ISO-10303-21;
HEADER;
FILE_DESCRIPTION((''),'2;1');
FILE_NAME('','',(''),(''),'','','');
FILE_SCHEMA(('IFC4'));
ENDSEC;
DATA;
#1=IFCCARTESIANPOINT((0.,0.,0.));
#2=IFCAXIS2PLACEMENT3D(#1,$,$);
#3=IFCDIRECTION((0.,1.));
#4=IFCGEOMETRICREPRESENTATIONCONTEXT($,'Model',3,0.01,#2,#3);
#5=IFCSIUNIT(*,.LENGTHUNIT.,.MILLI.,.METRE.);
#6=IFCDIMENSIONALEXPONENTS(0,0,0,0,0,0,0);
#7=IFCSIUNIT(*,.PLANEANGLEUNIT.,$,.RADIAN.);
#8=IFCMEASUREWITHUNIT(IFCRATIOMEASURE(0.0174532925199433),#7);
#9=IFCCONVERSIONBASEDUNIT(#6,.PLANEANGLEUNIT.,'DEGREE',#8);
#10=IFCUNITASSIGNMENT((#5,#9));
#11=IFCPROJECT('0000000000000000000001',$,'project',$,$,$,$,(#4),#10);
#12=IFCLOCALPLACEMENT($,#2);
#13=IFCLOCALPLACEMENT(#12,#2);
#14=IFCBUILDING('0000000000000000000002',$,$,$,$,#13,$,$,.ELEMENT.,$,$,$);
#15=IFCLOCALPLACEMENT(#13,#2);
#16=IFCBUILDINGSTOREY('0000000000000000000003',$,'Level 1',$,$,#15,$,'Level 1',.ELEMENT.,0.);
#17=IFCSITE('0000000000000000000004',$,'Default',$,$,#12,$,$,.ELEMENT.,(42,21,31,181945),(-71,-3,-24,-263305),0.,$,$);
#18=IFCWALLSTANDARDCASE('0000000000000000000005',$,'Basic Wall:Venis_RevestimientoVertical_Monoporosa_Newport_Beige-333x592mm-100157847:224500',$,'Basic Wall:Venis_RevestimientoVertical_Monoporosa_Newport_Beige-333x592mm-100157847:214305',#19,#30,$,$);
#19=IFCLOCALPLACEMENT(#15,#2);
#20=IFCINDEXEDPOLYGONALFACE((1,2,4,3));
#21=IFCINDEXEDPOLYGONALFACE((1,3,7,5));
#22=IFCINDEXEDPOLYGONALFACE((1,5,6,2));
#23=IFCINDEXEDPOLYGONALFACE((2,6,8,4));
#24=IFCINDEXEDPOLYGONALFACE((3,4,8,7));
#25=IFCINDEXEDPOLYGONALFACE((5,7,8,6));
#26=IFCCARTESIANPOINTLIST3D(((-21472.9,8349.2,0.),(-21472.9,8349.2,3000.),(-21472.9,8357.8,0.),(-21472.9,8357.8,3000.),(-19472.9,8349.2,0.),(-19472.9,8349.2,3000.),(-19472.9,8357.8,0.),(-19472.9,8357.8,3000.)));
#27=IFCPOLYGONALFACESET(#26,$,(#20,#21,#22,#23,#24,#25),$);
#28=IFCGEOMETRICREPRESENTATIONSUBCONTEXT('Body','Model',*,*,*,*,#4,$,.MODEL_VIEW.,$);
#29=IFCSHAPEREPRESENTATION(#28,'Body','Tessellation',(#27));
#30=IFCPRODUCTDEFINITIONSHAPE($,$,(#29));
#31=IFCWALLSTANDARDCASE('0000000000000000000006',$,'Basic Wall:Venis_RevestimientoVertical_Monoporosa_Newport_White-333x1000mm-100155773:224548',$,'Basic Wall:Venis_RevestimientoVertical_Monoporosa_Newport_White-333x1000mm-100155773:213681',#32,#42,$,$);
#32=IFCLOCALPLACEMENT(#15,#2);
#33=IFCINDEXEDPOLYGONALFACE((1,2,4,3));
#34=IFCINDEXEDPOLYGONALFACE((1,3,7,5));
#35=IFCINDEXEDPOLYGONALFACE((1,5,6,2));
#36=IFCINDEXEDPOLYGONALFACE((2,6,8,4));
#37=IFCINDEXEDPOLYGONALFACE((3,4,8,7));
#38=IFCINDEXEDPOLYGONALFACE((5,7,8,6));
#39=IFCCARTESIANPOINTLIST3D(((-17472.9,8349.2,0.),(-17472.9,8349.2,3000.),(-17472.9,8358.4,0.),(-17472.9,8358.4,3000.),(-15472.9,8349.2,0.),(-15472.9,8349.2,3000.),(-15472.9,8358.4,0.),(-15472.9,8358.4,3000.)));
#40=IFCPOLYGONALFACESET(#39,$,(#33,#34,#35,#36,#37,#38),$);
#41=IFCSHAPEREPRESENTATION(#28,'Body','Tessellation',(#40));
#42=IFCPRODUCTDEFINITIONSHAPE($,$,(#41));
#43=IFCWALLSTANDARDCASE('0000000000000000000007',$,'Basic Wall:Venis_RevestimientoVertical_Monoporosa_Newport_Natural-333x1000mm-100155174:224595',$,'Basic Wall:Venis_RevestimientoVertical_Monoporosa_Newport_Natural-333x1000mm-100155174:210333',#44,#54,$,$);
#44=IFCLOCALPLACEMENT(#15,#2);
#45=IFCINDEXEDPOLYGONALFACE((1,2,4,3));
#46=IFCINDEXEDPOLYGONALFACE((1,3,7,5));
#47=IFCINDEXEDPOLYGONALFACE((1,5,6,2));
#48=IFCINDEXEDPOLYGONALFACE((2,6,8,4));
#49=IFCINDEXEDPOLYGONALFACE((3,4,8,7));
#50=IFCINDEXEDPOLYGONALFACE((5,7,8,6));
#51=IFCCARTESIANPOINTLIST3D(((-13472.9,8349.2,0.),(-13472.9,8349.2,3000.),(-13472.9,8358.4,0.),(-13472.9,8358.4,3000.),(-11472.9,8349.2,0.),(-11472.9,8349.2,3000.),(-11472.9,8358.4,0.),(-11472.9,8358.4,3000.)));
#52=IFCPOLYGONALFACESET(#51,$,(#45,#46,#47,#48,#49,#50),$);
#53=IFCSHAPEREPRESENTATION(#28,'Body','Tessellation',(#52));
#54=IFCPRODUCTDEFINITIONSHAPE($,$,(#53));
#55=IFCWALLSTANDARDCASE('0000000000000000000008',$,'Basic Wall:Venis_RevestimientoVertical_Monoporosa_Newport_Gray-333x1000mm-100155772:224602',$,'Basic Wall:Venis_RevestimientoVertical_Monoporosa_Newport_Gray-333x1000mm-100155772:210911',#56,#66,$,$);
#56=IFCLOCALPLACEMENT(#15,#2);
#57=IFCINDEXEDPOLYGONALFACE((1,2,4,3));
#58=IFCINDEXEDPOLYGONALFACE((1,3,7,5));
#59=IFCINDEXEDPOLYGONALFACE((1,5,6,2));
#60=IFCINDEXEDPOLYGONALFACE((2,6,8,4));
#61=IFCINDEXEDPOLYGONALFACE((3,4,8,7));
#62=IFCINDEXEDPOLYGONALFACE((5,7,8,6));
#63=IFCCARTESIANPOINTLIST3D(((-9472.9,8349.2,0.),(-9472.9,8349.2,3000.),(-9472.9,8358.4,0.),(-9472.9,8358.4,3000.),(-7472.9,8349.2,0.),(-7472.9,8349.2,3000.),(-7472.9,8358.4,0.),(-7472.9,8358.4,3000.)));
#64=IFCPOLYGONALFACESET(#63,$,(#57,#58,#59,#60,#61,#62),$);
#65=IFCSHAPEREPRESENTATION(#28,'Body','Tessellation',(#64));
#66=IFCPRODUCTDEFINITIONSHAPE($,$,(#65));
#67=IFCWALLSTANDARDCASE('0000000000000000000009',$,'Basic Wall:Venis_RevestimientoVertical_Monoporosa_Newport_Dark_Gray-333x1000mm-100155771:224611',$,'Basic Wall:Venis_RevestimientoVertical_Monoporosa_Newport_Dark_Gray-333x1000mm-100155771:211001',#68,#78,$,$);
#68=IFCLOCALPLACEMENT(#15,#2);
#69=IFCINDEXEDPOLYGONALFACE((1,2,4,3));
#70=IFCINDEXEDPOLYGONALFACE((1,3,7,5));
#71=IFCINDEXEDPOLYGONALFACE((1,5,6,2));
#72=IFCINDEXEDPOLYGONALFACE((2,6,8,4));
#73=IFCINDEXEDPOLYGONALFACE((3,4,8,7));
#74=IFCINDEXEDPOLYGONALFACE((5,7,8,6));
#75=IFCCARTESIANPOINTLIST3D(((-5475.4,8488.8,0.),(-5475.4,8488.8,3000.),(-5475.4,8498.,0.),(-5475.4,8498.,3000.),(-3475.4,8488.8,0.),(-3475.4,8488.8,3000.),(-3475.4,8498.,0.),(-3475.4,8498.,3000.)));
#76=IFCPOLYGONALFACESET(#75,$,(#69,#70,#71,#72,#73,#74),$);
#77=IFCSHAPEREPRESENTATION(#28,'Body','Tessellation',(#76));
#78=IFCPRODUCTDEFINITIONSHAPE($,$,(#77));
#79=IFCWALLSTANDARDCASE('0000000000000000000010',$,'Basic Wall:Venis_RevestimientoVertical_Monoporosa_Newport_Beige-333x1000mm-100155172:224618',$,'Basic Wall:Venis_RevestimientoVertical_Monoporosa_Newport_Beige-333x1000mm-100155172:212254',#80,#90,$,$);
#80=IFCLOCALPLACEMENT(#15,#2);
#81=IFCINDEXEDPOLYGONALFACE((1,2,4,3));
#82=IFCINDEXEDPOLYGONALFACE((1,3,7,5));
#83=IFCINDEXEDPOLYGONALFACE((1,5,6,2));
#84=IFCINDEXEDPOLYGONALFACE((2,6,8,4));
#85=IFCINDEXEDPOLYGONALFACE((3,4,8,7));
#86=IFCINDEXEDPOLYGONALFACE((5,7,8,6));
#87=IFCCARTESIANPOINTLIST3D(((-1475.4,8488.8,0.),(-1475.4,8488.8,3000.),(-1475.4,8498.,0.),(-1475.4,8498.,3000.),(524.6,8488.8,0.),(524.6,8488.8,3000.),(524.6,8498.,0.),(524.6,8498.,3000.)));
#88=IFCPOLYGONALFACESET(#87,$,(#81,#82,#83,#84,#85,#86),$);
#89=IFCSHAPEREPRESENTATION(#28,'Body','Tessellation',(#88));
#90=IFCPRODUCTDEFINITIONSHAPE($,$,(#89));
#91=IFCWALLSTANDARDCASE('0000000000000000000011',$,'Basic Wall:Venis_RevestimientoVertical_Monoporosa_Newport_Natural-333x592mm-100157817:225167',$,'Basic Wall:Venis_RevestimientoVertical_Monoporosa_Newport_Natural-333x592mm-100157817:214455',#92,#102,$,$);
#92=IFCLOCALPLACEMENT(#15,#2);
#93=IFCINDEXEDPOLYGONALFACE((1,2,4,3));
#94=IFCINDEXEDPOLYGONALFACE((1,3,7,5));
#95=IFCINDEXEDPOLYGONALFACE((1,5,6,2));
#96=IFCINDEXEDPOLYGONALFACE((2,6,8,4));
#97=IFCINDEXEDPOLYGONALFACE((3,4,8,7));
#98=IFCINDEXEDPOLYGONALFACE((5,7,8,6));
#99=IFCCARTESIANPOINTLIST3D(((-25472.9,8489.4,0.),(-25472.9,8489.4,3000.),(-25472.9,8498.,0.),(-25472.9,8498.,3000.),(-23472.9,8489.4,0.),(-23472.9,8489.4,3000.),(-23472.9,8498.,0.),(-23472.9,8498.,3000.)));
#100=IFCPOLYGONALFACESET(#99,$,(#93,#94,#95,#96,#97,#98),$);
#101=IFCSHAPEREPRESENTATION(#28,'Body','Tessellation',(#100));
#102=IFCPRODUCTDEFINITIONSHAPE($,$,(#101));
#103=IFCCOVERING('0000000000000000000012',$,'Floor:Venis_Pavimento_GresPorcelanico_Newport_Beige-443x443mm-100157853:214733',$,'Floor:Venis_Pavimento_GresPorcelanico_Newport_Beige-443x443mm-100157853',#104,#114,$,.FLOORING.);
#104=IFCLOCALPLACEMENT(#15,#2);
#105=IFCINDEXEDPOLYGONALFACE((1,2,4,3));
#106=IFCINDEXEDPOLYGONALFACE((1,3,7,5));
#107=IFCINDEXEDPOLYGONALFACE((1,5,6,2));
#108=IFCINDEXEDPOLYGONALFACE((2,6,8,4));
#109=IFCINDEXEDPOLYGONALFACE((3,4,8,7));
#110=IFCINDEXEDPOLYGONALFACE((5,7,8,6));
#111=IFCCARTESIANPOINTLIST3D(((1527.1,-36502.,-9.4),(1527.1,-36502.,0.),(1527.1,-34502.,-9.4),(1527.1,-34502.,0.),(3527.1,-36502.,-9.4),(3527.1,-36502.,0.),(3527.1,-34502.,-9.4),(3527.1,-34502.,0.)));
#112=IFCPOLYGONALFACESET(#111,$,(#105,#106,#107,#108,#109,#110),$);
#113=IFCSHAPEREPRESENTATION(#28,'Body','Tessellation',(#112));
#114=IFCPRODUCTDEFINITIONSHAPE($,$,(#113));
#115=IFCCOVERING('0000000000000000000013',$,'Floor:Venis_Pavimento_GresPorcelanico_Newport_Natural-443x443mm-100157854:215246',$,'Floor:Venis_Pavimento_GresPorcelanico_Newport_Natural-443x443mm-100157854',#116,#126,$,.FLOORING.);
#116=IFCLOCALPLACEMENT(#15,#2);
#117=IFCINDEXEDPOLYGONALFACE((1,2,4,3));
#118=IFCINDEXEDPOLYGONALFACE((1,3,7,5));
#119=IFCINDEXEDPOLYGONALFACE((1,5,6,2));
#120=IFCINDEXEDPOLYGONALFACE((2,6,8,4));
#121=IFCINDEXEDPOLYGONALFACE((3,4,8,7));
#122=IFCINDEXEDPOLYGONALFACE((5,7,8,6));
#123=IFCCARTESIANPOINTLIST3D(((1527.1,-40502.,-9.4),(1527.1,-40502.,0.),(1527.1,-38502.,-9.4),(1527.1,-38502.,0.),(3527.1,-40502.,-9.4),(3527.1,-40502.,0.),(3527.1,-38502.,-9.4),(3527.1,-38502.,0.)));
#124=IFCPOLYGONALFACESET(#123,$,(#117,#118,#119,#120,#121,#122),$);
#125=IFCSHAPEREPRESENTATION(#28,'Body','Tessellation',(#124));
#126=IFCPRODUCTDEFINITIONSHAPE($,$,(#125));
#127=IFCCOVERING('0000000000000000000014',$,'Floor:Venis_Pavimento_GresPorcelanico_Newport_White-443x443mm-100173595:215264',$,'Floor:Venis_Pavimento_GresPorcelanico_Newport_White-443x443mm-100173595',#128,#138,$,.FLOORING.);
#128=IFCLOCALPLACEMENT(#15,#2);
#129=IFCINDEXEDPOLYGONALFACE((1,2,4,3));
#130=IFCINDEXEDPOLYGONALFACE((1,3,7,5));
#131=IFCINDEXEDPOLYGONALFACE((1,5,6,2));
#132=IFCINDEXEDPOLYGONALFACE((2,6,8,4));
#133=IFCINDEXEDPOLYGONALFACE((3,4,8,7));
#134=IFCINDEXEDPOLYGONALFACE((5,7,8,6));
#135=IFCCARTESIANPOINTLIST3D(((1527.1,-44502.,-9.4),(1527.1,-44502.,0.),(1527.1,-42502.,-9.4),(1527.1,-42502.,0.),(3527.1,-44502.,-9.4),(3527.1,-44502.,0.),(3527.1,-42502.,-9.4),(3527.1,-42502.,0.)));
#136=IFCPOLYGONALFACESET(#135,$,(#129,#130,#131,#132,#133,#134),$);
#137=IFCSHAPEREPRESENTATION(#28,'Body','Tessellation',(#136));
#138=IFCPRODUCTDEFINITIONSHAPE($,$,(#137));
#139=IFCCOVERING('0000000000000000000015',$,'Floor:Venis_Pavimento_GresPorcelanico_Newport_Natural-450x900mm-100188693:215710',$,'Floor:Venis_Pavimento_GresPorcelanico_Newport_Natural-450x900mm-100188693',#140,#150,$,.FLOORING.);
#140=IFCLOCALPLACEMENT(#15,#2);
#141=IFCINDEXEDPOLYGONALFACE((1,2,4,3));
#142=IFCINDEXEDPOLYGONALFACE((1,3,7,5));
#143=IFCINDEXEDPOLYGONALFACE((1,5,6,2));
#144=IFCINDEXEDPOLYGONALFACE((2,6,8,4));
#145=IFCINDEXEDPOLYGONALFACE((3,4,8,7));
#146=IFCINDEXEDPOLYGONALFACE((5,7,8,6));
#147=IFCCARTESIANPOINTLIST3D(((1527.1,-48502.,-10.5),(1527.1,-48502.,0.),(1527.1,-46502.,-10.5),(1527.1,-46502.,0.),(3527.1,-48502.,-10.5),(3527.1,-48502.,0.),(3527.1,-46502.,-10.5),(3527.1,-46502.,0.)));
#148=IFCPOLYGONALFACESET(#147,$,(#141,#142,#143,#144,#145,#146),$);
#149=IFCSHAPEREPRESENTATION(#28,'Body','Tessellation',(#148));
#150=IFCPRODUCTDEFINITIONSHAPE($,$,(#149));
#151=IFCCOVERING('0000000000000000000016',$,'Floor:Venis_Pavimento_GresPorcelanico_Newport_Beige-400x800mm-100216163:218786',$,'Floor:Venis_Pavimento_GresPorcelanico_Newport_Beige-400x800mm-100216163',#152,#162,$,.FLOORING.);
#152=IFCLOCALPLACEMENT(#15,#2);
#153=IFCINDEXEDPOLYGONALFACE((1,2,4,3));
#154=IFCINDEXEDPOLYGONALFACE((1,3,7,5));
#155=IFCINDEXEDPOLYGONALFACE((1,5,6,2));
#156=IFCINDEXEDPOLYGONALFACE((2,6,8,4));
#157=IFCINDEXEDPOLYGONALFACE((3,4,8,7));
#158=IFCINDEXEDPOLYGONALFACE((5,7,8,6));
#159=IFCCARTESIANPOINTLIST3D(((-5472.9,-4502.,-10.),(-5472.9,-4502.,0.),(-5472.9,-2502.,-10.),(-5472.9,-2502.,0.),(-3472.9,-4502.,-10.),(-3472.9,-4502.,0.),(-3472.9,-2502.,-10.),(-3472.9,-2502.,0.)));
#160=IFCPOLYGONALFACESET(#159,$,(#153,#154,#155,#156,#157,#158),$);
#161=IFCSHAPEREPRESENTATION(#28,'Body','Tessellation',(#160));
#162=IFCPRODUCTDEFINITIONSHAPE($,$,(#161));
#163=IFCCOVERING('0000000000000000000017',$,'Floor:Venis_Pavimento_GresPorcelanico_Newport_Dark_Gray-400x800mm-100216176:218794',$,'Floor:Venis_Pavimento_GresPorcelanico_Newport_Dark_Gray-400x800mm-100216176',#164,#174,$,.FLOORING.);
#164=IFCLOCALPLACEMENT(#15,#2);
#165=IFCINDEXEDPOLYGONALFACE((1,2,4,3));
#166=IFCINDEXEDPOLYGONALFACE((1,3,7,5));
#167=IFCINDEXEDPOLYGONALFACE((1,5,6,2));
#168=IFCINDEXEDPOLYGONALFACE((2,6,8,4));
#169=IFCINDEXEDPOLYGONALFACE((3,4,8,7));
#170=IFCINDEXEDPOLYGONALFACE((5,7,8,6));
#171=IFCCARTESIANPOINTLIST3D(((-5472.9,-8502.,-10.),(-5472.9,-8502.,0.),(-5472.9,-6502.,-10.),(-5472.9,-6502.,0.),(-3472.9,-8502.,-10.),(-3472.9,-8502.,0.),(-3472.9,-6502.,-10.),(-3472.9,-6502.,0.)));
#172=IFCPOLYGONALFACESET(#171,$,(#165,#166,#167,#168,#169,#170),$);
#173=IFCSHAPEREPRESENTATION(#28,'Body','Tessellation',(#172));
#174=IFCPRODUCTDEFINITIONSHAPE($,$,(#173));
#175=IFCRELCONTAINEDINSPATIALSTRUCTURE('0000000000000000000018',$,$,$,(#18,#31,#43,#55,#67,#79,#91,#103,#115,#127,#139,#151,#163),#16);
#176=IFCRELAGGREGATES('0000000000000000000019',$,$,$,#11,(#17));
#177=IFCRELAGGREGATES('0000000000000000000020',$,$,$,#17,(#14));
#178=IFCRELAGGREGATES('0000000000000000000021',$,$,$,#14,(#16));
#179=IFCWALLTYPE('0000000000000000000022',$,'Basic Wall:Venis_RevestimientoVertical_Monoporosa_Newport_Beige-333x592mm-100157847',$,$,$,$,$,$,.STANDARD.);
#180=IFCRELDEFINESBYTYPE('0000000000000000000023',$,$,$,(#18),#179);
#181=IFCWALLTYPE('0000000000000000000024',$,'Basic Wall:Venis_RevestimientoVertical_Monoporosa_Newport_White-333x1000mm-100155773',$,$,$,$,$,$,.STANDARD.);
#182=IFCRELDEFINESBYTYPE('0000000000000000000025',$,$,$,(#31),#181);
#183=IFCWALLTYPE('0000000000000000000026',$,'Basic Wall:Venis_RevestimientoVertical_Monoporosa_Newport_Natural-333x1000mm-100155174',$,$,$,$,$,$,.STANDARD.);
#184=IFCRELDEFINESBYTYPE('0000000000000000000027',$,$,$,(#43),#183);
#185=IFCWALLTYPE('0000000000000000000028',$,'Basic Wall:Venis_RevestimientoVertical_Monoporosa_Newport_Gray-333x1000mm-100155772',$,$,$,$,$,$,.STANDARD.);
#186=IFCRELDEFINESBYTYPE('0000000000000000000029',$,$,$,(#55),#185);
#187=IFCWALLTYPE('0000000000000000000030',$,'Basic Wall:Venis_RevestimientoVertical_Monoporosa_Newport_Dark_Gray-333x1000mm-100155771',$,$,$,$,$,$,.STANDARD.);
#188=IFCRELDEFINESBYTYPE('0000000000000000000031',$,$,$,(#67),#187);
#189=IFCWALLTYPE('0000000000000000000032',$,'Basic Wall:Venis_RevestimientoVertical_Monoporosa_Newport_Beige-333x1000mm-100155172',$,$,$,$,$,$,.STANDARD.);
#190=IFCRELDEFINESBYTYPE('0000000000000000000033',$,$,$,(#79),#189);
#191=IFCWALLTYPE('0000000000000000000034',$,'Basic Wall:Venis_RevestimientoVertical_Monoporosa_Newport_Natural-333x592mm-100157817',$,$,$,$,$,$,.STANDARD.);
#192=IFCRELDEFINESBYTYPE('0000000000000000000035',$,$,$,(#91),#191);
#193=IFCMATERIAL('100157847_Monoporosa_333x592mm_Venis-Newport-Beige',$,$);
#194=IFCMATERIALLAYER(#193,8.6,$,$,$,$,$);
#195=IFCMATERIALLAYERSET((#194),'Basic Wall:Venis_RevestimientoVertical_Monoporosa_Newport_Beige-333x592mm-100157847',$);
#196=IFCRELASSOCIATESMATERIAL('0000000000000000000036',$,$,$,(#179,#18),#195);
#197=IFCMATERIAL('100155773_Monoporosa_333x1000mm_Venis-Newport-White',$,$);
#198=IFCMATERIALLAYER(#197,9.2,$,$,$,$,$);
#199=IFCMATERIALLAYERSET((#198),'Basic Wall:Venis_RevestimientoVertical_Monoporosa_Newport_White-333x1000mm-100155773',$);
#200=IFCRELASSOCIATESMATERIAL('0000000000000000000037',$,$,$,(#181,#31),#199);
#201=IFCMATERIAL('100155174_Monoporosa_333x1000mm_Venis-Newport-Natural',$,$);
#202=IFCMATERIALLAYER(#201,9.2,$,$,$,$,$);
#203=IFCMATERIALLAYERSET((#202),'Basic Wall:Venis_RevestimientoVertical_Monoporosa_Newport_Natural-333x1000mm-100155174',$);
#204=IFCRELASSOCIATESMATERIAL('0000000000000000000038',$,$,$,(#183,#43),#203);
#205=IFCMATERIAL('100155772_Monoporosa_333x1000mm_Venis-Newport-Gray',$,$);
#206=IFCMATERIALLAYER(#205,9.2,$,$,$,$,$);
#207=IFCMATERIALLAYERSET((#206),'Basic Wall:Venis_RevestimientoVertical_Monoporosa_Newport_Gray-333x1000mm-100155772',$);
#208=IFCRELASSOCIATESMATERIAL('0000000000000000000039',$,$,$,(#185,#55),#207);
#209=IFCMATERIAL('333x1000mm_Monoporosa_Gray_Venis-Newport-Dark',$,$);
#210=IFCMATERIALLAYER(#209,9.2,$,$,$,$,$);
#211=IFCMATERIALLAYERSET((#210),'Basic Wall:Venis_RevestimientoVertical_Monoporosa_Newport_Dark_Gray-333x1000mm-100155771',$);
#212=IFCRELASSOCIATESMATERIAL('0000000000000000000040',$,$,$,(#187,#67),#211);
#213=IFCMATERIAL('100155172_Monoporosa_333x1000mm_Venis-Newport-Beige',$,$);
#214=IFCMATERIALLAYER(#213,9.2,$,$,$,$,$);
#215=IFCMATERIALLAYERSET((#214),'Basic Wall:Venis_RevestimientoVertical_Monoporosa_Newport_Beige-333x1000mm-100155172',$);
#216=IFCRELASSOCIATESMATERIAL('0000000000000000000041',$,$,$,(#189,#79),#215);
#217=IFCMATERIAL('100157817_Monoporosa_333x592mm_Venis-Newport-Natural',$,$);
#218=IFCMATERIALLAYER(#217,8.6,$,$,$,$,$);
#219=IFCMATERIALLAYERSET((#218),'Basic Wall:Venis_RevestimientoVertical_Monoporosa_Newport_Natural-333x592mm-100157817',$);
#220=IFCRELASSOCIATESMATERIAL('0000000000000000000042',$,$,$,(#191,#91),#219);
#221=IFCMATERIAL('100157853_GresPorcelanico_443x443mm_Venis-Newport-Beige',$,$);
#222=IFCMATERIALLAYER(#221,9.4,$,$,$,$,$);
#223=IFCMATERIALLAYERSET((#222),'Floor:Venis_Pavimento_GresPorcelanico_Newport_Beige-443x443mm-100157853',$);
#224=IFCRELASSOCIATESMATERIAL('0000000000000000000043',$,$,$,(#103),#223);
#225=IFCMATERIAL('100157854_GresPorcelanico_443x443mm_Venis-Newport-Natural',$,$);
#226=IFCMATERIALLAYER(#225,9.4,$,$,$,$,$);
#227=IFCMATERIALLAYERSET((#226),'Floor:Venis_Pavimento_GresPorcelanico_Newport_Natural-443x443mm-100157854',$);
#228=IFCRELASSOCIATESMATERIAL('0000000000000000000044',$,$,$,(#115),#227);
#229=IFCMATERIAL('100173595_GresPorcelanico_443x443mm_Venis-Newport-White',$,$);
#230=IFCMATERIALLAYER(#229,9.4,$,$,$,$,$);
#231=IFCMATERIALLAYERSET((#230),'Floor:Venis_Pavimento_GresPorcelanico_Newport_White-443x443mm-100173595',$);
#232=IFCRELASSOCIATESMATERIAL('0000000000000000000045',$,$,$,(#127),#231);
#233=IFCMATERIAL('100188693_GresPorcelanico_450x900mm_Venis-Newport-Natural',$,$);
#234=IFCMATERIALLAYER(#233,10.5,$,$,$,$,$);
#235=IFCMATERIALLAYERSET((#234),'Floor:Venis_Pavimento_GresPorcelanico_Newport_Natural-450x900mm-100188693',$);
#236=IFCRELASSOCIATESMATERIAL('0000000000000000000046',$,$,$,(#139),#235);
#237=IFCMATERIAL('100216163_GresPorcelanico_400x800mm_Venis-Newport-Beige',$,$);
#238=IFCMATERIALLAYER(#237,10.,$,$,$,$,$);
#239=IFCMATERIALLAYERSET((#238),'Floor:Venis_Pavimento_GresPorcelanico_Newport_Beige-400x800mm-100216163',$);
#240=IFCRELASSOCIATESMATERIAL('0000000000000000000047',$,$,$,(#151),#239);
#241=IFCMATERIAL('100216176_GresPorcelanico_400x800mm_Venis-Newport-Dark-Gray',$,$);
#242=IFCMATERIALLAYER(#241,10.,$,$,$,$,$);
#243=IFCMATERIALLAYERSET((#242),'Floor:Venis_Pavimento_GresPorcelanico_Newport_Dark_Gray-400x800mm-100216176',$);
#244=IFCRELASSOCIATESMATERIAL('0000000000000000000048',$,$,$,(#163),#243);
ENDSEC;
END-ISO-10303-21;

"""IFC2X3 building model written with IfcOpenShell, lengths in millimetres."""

from ifc_helpers import new_model, entity, si_unit, converted_unit, direction, frame, frame_2d, origin, place, context, subcontext, project, spatial, rectangle, extrude, material, layer, layer_set, layer_usage, type_object, element, save


model = new_model("IFC2X3")

# Units and contexts
model_context = context("Model", 3, precision=0.01, world=origin(), true_north=direction((0.0, 1.0)))
body_context = subcontext(model_context, "Body", "Model", "MODEL_VIEW")
ifc_project = project(units=[si_unit("LENGTHUNIT", "METRE", prefix="MILLI"), converted_unit("PLANEANGLEUNIT", "DEGREE", entity("IfcRatioMeasure", 0.0174532925199433), si_unit("PLANEANGLEUNIT", "RADIAN"), dimensions=[0, 0, 0, 0, 0, 0, 0])], contexts=[model_context])

# Site, building, storey
site_placement = place(None, origin())
site = spatial("IfcSite", under=ifc_project, at=site_placement, Name="Default", CompositionType="ELEMENT", RefLatitude=(42, 21, 31, 181945), RefLongitude=(-71, -3, -24, -263305), RefElevation=0.0)
building_placement = place(site_placement, origin())
building = spatial("IfcBuilding", under=site, at=building_placement, CompositionType="ELEMENT")
storey_placement = place(building_placement, origin())
storey = spatial("IfcBuildingStorey", under=building, at=storey_placement, Name="Level 1", LongName="Level 1", CompositionType="ELEMENT", Elevation=0.0)

# Walls
ifc_material_1 = material(Name="100157847_Monoporosa_333x592mm_Venis-Newport-Beige")
ifc_layer_1 = layer(ifc_material_1, 8.6)
ifc_layer_set_1 = layer_set([ifc_layer_1], Name="Basic Wall:Venis_RevestimientoVertical_Monoporosa_Newport_Beige-333x592mm-100157847")
ifc_layer_usage_1 = layer_usage(ifc_layer_set_1, "AXIS2", "NEGATIVE", 4.3)
wall_type_1 = type_object("IfcWallType", Name="Basic Wall:Venis_RevestimientoVertical_Monoporosa_Newport_Beige-333x592mm-100157847", PredefinedType="STANDARD", material=ifc_layer_set_1)
wall_1_placement = place(storey_placement, frame((-21472.9, 8353.5, 0.0)))
element("IfcWallStandardCase", 1, at=wall_1_placement, inside=storey, type_object=wall_type_1, material=ifc_layer_usage_1, Name="Basic Wall:Venis_RevestimientoVertical_Monoporosa_Newport_Beige-333x592mm-100157847:224500", ObjectType="Basic Wall:Venis_RevestimientoVertical_Monoporosa_Newport_Beige-333x592mm-100157847:214305", context=body_context, shape_type="SweptSolid", body=[
    extrude(rectangle(XDim=2000.0, YDim=8.6, at=frame_2d((1000.0, 0.0), x_axis=(-1.0, 0.0))), origin(), (0.0, 0.0, 1.0), 3000.0),
])
ifc_material_2 = material(Name="100155773_Monoporosa_333x1000mm_Venis-Newport-White")
ifc_layer_2 = layer(ifc_material_2, 9.2)
ifc_layer_set_2 = layer_set([ifc_layer_2], Name="Basic Wall:Venis_RevestimientoVertical_Monoporosa_Newport_White-333x1000mm-100155773")
ifc_layer_usage_2 = layer_usage(ifc_layer_set_2, "AXIS2", "NEGATIVE", 4.6)
wall_type_2 = type_object("IfcWallType", Name="Basic Wall:Venis_RevestimientoVertical_Monoporosa_Newport_White-333x1000mm-100155773", PredefinedType="STANDARD", material=ifc_layer_set_2)
wall_2_placement = place(storey_placement, frame((-17472.9, 8353.8, 0.0)))
element("IfcWallStandardCase", 2, at=wall_2_placement, inside=storey, type_object=wall_type_2, material=ifc_layer_usage_2, Name="Basic Wall:Venis_RevestimientoVertical_Monoporosa_Newport_White-333x1000mm-100155773:224548", ObjectType="Basic Wall:Venis_RevestimientoVertical_Monoporosa_Newport_White-333x1000mm-100155773:213681", context=body_context, shape_type="SweptSolid", body=[
    extrude(rectangle(XDim=2000.0, YDim=9.2, at=frame_2d((1000.0, 0.0), x_axis=(-1.0, 0.0))), origin(), (0.0, 0.0, 1.0), 3000.0),
])
ifc_material_3 = material(Name="100155174_Monoporosa_333x1000mm_Venis-Newport-Natural")
ifc_layer_3 = layer(ifc_material_3, 9.2)
ifc_layer_set_3 = layer_set([ifc_layer_3], Name="Basic Wall:Venis_RevestimientoVertical_Monoporosa_Newport_Natural-333x1000mm-100155174")
ifc_layer_usage_3 = layer_usage(ifc_layer_set_3, "AXIS2", "NEGATIVE", 4.6)
wall_type_3 = type_object("IfcWallType", Name="Basic Wall:Venis_RevestimientoVertical_Monoporosa_Newport_Natural-333x1000mm-100155174", PredefinedType="STANDARD", material=ifc_layer_set_3)
wall_3_placement = place(storey_placement, frame((-13472.9, 8353.8, 0.0)))
element("IfcWallStandardCase", 3, at=wall_3_placement, inside=storey, type_object=wall_type_3, material=ifc_layer_usage_3, Name="Basic Wall:Venis_RevestimientoVertical_Monoporosa_Newport_Natural-333x1000mm-100155174:224595", ObjectType="Basic Wall:Venis_RevestimientoVertical_Monoporosa_Newport_Natural-333x1000mm-100155174:210333", context=body_context, shape_type="SweptSolid", body=[
    extrude(rectangle(XDim=2000.0, YDim=9.2, at=frame_2d((1000.0, 0.0), x_axis=(-1.0, 0.0))), origin(), (0.0, 0.0, 1.0), 3000.0),
])
ifc_material_4 = material(Name="100155772_Monoporosa_333x1000mm_Venis-Newport-Gray")
ifc_layer_4 = layer(ifc_material_4, 9.2)
ifc_layer_set_4 = layer_set([ifc_layer_4], Name="Basic Wall:Venis_RevestimientoVertical_Monoporosa_Newport_Gray-333x1000mm-100155772")
ifc_layer_usage_4 = layer_usage(ifc_layer_set_4, "AXIS2", "NEGATIVE", 4.6)
wall_type_4 = type_object("IfcWallType", Name="Basic Wall:Venis_RevestimientoVertical_Monoporosa_Newport_Gray-333x1000mm-100155772", PredefinedType="STANDARD", material=ifc_layer_set_4)
wall_4_placement = place(storey_placement, frame((-9472.9, 8353.8, 0.0)))
element("IfcWallStandardCase", 4, at=wall_4_placement, inside=storey, type_object=wall_type_4, material=ifc_layer_usage_4, Name="Basic Wall:Venis_RevestimientoVertical_Monoporosa_Newport_Gray-333x1000mm-100155772:224602", ObjectType="Basic Wall:Venis_RevestimientoVertical_Monoporosa_Newport_Gray-333x1000mm-100155772:210911", context=body_context, shape_type="SweptSolid", body=[
    extrude(rectangle(XDim=2000.0, YDim=9.2, at=frame_2d((1000.0, 0.0), x_axis=(-1.0, 0.0))), origin(), (0.0, 0.0, 1.0), 3000.0),
])
ifc_material_5 = material(Name="333x1000mm_Monoporosa_Gray_Venis-Newport-Dark")
ifc_layer_5 = layer(ifc_material_5, 9.2)
ifc_layer_set_5 = layer_set([ifc_layer_5], Name="Basic Wall:Venis_RevestimientoVertical_Monoporosa_Newport_Dark_Gray-333x1000mm-100155771")
ifc_layer_usage_5 = layer_usage(ifc_layer_set_5, "AXIS2", "NEGATIVE", 4.6)
wall_type_5 = type_object("IfcWallType", Name="Basic Wall:Venis_RevestimientoVertical_Monoporosa_Newport_Dark_Gray-333x1000mm-100155771", PredefinedType="STANDARD", material=ifc_layer_set_5)
wall_5_placement = place(storey_placement, frame((-5475.4, 8493.4, 0.0)))
element("IfcWallStandardCase", 5, at=wall_5_placement, inside=storey, type_object=wall_type_5, material=ifc_layer_usage_5, Name="Basic Wall:Venis_RevestimientoVertical_Monoporosa_Newport_Dark_Gray-333x1000mm-100155771:224611", ObjectType="Basic Wall:Venis_RevestimientoVertical_Monoporosa_Newport_Dark_Gray-333x1000mm-100155771:211001", context=body_context, shape_type="SweptSolid", body=[
    extrude(rectangle(XDim=2000.0, YDim=9.2, at=frame_2d((1000.0, 0.0), x_axis=(-1.0, 0.0))), origin(), (0.0, 0.0, 1.0), 3000.0),
])
ifc_material_6 = material(Name="100155172_Monoporosa_333x1000mm_Venis-Newport-Beige")
ifc_layer_6 = layer(ifc_material_6, 9.2)
ifc_layer_set_6 = layer_set([ifc_layer_6], Name="Basic Wall:Venis_RevestimientoVertical_Monoporosa_Newport_Beige-333x1000mm-100155172")
ifc_layer_usage_6 = layer_usage(ifc_layer_set_6, "AXIS2", "NEGATIVE", 4.6)
wall_type_6 = type_object("IfcWallType", Name="Basic Wall:Venis_RevestimientoVertical_Monoporosa_Newport_Beige-333x1000mm-100155172", PredefinedType="STANDARD", material=ifc_layer_set_6)
wall_6_placement = place(storey_placement, frame((-1475.4, 8493.4, 0.0)))
element("IfcWallStandardCase", 6, at=wall_6_placement, inside=storey, type_object=wall_type_6, material=ifc_layer_usage_6, Name="Basic Wall:Venis_RevestimientoVertical_Monoporosa_Newport_Beige-333x1000mm-100155172:224618", ObjectType="Basic Wall:Venis_RevestimientoVertical_Monoporosa_Newport_Beige-333x1000mm-100155172:212254", context=body_context, shape_type="SweptSolid", body=[
    extrude(rectangle(XDim=2000.0, YDim=9.2, at=frame_2d((1000.0, 0.0), x_axis=(-1.0, 0.0))), origin(), (0.0, 0.0, 1.0), 3000.0),
])
ifc_material_7 = material(Name="100157817_Monoporosa_333x592mm_Venis-Newport-Natural")
ifc_layer_7 = layer(ifc_material_7, 8.6)
ifc_layer_set_7 = layer_set([ifc_layer_7], Name="Basic Wall:Venis_RevestimientoVertical_Monoporosa_Newport_Natural-333x592mm-100157817")
ifc_layer_usage_7 = layer_usage(ifc_layer_set_7, "AXIS2", "NEGATIVE", 4.3)
wall_type_7 = type_object("IfcWallType", Name="Basic Wall:Venis_RevestimientoVertical_Monoporosa_Newport_Natural-333x592mm-100157817", PredefinedType="STANDARD", material=ifc_layer_set_7)
wall_7_placement = place(storey_placement, frame((-25472.9, 8493.7, 0.0)))
element("IfcWallStandardCase", 7, at=wall_7_placement, inside=storey, type_object=wall_type_7, material=ifc_layer_usage_7, Name="Basic Wall:Venis_RevestimientoVertical_Monoporosa_Newport_Natural-333x592mm-100157817:225167", ObjectType="Basic Wall:Venis_RevestimientoVertical_Monoporosa_Newport_Natural-333x592mm-100157817:214455", context=body_context, shape_type="SweptSolid", body=[
    extrude(rectangle(XDim=2000.0, YDim=8.6, at=frame_2d((1000.0, 0.0), x_axis=(-1.0, 0.0))), origin(), (0.0, 0.0, 1.0), 3000.0),
])

# Coverings
ifc_material_8 = material(Name="100157853_GresPorcelanico_443x443mm_Venis-Newport-Beige")
ifc_layer_8 = layer(ifc_material_8, 9.4)
ifc_layer_set_8 = layer_set([ifc_layer_8], Name="Floor:Venis_Pavimento_GresPorcelanico_Newport_Beige-443x443mm-100157853")
ifc_layer_usage_8 = layer_usage(ifc_layer_set_8, "AXIS3", "POSITIVE", 0.0)
covering_1_placement = place(storey_placement, origin())
element("IfcCovering", 8, at=covering_1_placement, inside=storey, material=ifc_layer_usage_8, Name="Floor:Venis_Pavimento_GresPorcelanico_Newport_Beige-443x443mm-100157853:214733", ObjectType="Floor:Venis_Pavimento_GresPorcelanico_Newport_Beige-443x443mm-100157853", PredefinedType="FLOORING", context=body_context, shape_type="SweptSolid", body=[
    extrude(rectangle(XDim=2000.0, YDim=2000.0, at=frame_2d((0.0, 0.0), x_axis=(1.0, 0.0))), frame((2527.1, -35502.0, 0.0), z_axis=(0.0, 0.0, -1.0), x_axis=(0.0, 1.0, 0.0)), (0.0, 0.0, 1.0), 9.4),
])
ifc_material_9 = material(Name="100157854_GresPorcelanico_443x443mm_Venis-Newport-Natural")
ifc_layer_9 = layer(ifc_material_9, 9.4)
ifc_layer_set_9 = layer_set([ifc_layer_9], Name="Floor:Venis_Pavimento_GresPorcelanico_Newport_Natural-443x443mm-100157854")
ifc_layer_usage_9 = layer_usage(ifc_layer_set_9, "AXIS3", "POSITIVE", 0.0)
covering_2_placement = place(storey_placement, origin())
element("IfcCovering", 9, at=covering_2_placement, inside=storey, material=ifc_layer_usage_9, Name="Floor:Venis_Pavimento_GresPorcelanico_Newport_Natural-443x443mm-100157854:215246", ObjectType="Floor:Venis_Pavimento_GresPorcelanico_Newport_Natural-443x443mm-100157854", PredefinedType="FLOORING", context=body_context, shape_type="SweptSolid", body=[
    extrude(rectangle(XDim=2000.0, YDim=2000.0, at=frame_2d((0.0, 0.0), x_axis=(1.0, 0.0))), frame((2527.1, -39502.0, 0.0), z_axis=(0.0, 0.0, -1.0), x_axis=(0.0, 1.0, 0.0)), (0.0, 0.0, 1.0), 9.4),
])
ifc_material_10 = material(Name="100173595_GresPorcelanico_443x443mm_Venis-Newport-White")
ifc_layer_10 = layer(ifc_material_10, 9.4)
ifc_layer_set_10 = layer_set([ifc_layer_10], Name="Floor:Venis_Pavimento_GresPorcelanico_Newport_White-443x443mm-100173595")
ifc_layer_usage_10 = layer_usage(ifc_layer_set_10, "AXIS3", "POSITIVE", 0.0)
covering_3_placement = place(storey_placement, origin())
element("IfcCovering", 10, at=covering_3_placement, inside=storey, material=ifc_layer_usage_10, Name="Floor:Venis_Pavimento_GresPorcelanico_Newport_White-443x443mm-100173595:215264", ObjectType="Floor:Venis_Pavimento_GresPorcelanico_Newport_White-443x443mm-100173595", PredefinedType="FLOORING", context=body_context, shape_type="SweptSolid", body=[
    extrude(rectangle(XDim=2000.0, YDim=2000.0, at=frame_2d((0.0, 0.0), x_axis=(1.0, 0.0))), frame((2527.1, -43502.0, 0.0), z_axis=(0.0, 0.0, -1.0), x_axis=(0.0, 1.0, 0.0)), (0.0, 0.0, 1.0), 9.4),
])
ifc_material_11 = material(Name="100188693_GresPorcelanico_450x900mm_Venis-Newport-Natural")
ifc_layer_11 = layer(ifc_material_11, 10.5)
ifc_layer_set_11 = layer_set([ifc_layer_11], Name="Floor:Venis_Pavimento_GresPorcelanico_Newport_Natural-450x900mm-100188693")
ifc_layer_usage_11 = layer_usage(ifc_layer_set_11, "AXIS3", "POSITIVE", 0.0)
covering_4_placement = place(storey_placement, origin())
element("IfcCovering", 11, at=covering_4_placement, inside=storey, material=ifc_layer_usage_11, Name="Floor:Venis_Pavimento_GresPorcelanico_Newport_Natural-450x900mm-100188693:215710", ObjectType="Floor:Venis_Pavimento_GresPorcelanico_Newport_Natural-450x900mm-100188693", PredefinedType="FLOORING", context=body_context, shape_type="SweptSolid", body=[
    extrude(rectangle(XDim=2000.0, YDim=2000.0, at=frame_2d((0.0, 0.0), x_axis=(1.0, 0.0))), frame((2527.1, -47502.0, 0.0), z_axis=(0.0, 0.0, -1.0), x_axis=(0.0, 1.0, 0.0)), (0.0, 0.0, 1.0), 10.5),
])
ifc_material_12 = material(Name="100216163_GresPorcelanico_400x800mm_Venis-Newport-Beige")
ifc_layer_12 = layer(ifc_material_12, 10.0)
ifc_layer_set_12 = layer_set([ifc_layer_12], Name="Floor:Venis_Pavimento_GresPorcelanico_Newport_Beige-400x800mm-100216163")
ifc_layer_usage_12 = layer_usage(ifc_layer_set_12, "AXIS3", "POSITIVE", 0.0)
covering_5_placement = place(storey_placement, origin())
element("IfcCovering", 12, at=covering_5_placement, inside=storey, material=ifc_layer_usage_12, Name="Floor:Venis_Pavimento_GresPorcelanico_Newport_Beige-400x800mm-100216163:218786", ObjectType="Floor:Venis_Pavimento_GresPorcelanico_Newport_Beige-400x800mm-100216163", PredefinedType="FLOORING", context=body_context, shape_type="SweptSolid", body=[
    extrude(rectangle(XDim=2000.0, YDim=2000.0, at=frame_2d((0.0, 0.0), x_axis=(1.0, 0.0))), frame((-4472.9, -3502.0, 0.0), z_axis=(0.0, 0.0, -1.0), x_axis=(0.0, 1.0, 0.0)), (0.0, 0.0, 1.0), 10.0),
])
ifc_material_13 = material(Name="100216176_GresPorcelanico_400x800mm_Venis-Newport-Dark-Gray")
ifc_layer_13 = layer(ifc_material_13, 10.0)
ifc_layer_set_13 = layer_set([ifc_layer_13], Name="Floor:Venis_Pavimento_GresPorcelanico_Newport_Dark_Gray-400x800mm-100216176")
ifc_layer_usage_13 = layer_usage(ifc_layer_set_13, "AXIS3", "POSITIVE", 0.0)
covering_6_placement = place(storey_placement, origin())
element("IfcCovering", 13, at=covering_6_placement, inside=storey, material=ifc_layer_usage_13, Name="Floor:Venis_Pavimento_GresPorcelanico_Newport_Dark_Gray-400x800mm-100216176:218794", ObjectType="Floor:Venis_Pavimento_GresPorcelanico_Newport_Dark_Gray-400x800mm-100216176", PredefinedType="FLOORING", context=body_context, shape_type="SweptSolid", body=[
    extrude(rectangle(XDim=2000.0, YDim=2000.0, at=frame_2d((0.0, 0.0), x_axis=(1.0, 0.0))), frame((-4472.9, -7502.0, 0.0), z_axis=(0.0, 0.0, -1.0), x_axis=(0.0, 1.0, 0.0)), (0.0, 0.0, 1.0), 10.0),
])

save(model, "model.ifc")
